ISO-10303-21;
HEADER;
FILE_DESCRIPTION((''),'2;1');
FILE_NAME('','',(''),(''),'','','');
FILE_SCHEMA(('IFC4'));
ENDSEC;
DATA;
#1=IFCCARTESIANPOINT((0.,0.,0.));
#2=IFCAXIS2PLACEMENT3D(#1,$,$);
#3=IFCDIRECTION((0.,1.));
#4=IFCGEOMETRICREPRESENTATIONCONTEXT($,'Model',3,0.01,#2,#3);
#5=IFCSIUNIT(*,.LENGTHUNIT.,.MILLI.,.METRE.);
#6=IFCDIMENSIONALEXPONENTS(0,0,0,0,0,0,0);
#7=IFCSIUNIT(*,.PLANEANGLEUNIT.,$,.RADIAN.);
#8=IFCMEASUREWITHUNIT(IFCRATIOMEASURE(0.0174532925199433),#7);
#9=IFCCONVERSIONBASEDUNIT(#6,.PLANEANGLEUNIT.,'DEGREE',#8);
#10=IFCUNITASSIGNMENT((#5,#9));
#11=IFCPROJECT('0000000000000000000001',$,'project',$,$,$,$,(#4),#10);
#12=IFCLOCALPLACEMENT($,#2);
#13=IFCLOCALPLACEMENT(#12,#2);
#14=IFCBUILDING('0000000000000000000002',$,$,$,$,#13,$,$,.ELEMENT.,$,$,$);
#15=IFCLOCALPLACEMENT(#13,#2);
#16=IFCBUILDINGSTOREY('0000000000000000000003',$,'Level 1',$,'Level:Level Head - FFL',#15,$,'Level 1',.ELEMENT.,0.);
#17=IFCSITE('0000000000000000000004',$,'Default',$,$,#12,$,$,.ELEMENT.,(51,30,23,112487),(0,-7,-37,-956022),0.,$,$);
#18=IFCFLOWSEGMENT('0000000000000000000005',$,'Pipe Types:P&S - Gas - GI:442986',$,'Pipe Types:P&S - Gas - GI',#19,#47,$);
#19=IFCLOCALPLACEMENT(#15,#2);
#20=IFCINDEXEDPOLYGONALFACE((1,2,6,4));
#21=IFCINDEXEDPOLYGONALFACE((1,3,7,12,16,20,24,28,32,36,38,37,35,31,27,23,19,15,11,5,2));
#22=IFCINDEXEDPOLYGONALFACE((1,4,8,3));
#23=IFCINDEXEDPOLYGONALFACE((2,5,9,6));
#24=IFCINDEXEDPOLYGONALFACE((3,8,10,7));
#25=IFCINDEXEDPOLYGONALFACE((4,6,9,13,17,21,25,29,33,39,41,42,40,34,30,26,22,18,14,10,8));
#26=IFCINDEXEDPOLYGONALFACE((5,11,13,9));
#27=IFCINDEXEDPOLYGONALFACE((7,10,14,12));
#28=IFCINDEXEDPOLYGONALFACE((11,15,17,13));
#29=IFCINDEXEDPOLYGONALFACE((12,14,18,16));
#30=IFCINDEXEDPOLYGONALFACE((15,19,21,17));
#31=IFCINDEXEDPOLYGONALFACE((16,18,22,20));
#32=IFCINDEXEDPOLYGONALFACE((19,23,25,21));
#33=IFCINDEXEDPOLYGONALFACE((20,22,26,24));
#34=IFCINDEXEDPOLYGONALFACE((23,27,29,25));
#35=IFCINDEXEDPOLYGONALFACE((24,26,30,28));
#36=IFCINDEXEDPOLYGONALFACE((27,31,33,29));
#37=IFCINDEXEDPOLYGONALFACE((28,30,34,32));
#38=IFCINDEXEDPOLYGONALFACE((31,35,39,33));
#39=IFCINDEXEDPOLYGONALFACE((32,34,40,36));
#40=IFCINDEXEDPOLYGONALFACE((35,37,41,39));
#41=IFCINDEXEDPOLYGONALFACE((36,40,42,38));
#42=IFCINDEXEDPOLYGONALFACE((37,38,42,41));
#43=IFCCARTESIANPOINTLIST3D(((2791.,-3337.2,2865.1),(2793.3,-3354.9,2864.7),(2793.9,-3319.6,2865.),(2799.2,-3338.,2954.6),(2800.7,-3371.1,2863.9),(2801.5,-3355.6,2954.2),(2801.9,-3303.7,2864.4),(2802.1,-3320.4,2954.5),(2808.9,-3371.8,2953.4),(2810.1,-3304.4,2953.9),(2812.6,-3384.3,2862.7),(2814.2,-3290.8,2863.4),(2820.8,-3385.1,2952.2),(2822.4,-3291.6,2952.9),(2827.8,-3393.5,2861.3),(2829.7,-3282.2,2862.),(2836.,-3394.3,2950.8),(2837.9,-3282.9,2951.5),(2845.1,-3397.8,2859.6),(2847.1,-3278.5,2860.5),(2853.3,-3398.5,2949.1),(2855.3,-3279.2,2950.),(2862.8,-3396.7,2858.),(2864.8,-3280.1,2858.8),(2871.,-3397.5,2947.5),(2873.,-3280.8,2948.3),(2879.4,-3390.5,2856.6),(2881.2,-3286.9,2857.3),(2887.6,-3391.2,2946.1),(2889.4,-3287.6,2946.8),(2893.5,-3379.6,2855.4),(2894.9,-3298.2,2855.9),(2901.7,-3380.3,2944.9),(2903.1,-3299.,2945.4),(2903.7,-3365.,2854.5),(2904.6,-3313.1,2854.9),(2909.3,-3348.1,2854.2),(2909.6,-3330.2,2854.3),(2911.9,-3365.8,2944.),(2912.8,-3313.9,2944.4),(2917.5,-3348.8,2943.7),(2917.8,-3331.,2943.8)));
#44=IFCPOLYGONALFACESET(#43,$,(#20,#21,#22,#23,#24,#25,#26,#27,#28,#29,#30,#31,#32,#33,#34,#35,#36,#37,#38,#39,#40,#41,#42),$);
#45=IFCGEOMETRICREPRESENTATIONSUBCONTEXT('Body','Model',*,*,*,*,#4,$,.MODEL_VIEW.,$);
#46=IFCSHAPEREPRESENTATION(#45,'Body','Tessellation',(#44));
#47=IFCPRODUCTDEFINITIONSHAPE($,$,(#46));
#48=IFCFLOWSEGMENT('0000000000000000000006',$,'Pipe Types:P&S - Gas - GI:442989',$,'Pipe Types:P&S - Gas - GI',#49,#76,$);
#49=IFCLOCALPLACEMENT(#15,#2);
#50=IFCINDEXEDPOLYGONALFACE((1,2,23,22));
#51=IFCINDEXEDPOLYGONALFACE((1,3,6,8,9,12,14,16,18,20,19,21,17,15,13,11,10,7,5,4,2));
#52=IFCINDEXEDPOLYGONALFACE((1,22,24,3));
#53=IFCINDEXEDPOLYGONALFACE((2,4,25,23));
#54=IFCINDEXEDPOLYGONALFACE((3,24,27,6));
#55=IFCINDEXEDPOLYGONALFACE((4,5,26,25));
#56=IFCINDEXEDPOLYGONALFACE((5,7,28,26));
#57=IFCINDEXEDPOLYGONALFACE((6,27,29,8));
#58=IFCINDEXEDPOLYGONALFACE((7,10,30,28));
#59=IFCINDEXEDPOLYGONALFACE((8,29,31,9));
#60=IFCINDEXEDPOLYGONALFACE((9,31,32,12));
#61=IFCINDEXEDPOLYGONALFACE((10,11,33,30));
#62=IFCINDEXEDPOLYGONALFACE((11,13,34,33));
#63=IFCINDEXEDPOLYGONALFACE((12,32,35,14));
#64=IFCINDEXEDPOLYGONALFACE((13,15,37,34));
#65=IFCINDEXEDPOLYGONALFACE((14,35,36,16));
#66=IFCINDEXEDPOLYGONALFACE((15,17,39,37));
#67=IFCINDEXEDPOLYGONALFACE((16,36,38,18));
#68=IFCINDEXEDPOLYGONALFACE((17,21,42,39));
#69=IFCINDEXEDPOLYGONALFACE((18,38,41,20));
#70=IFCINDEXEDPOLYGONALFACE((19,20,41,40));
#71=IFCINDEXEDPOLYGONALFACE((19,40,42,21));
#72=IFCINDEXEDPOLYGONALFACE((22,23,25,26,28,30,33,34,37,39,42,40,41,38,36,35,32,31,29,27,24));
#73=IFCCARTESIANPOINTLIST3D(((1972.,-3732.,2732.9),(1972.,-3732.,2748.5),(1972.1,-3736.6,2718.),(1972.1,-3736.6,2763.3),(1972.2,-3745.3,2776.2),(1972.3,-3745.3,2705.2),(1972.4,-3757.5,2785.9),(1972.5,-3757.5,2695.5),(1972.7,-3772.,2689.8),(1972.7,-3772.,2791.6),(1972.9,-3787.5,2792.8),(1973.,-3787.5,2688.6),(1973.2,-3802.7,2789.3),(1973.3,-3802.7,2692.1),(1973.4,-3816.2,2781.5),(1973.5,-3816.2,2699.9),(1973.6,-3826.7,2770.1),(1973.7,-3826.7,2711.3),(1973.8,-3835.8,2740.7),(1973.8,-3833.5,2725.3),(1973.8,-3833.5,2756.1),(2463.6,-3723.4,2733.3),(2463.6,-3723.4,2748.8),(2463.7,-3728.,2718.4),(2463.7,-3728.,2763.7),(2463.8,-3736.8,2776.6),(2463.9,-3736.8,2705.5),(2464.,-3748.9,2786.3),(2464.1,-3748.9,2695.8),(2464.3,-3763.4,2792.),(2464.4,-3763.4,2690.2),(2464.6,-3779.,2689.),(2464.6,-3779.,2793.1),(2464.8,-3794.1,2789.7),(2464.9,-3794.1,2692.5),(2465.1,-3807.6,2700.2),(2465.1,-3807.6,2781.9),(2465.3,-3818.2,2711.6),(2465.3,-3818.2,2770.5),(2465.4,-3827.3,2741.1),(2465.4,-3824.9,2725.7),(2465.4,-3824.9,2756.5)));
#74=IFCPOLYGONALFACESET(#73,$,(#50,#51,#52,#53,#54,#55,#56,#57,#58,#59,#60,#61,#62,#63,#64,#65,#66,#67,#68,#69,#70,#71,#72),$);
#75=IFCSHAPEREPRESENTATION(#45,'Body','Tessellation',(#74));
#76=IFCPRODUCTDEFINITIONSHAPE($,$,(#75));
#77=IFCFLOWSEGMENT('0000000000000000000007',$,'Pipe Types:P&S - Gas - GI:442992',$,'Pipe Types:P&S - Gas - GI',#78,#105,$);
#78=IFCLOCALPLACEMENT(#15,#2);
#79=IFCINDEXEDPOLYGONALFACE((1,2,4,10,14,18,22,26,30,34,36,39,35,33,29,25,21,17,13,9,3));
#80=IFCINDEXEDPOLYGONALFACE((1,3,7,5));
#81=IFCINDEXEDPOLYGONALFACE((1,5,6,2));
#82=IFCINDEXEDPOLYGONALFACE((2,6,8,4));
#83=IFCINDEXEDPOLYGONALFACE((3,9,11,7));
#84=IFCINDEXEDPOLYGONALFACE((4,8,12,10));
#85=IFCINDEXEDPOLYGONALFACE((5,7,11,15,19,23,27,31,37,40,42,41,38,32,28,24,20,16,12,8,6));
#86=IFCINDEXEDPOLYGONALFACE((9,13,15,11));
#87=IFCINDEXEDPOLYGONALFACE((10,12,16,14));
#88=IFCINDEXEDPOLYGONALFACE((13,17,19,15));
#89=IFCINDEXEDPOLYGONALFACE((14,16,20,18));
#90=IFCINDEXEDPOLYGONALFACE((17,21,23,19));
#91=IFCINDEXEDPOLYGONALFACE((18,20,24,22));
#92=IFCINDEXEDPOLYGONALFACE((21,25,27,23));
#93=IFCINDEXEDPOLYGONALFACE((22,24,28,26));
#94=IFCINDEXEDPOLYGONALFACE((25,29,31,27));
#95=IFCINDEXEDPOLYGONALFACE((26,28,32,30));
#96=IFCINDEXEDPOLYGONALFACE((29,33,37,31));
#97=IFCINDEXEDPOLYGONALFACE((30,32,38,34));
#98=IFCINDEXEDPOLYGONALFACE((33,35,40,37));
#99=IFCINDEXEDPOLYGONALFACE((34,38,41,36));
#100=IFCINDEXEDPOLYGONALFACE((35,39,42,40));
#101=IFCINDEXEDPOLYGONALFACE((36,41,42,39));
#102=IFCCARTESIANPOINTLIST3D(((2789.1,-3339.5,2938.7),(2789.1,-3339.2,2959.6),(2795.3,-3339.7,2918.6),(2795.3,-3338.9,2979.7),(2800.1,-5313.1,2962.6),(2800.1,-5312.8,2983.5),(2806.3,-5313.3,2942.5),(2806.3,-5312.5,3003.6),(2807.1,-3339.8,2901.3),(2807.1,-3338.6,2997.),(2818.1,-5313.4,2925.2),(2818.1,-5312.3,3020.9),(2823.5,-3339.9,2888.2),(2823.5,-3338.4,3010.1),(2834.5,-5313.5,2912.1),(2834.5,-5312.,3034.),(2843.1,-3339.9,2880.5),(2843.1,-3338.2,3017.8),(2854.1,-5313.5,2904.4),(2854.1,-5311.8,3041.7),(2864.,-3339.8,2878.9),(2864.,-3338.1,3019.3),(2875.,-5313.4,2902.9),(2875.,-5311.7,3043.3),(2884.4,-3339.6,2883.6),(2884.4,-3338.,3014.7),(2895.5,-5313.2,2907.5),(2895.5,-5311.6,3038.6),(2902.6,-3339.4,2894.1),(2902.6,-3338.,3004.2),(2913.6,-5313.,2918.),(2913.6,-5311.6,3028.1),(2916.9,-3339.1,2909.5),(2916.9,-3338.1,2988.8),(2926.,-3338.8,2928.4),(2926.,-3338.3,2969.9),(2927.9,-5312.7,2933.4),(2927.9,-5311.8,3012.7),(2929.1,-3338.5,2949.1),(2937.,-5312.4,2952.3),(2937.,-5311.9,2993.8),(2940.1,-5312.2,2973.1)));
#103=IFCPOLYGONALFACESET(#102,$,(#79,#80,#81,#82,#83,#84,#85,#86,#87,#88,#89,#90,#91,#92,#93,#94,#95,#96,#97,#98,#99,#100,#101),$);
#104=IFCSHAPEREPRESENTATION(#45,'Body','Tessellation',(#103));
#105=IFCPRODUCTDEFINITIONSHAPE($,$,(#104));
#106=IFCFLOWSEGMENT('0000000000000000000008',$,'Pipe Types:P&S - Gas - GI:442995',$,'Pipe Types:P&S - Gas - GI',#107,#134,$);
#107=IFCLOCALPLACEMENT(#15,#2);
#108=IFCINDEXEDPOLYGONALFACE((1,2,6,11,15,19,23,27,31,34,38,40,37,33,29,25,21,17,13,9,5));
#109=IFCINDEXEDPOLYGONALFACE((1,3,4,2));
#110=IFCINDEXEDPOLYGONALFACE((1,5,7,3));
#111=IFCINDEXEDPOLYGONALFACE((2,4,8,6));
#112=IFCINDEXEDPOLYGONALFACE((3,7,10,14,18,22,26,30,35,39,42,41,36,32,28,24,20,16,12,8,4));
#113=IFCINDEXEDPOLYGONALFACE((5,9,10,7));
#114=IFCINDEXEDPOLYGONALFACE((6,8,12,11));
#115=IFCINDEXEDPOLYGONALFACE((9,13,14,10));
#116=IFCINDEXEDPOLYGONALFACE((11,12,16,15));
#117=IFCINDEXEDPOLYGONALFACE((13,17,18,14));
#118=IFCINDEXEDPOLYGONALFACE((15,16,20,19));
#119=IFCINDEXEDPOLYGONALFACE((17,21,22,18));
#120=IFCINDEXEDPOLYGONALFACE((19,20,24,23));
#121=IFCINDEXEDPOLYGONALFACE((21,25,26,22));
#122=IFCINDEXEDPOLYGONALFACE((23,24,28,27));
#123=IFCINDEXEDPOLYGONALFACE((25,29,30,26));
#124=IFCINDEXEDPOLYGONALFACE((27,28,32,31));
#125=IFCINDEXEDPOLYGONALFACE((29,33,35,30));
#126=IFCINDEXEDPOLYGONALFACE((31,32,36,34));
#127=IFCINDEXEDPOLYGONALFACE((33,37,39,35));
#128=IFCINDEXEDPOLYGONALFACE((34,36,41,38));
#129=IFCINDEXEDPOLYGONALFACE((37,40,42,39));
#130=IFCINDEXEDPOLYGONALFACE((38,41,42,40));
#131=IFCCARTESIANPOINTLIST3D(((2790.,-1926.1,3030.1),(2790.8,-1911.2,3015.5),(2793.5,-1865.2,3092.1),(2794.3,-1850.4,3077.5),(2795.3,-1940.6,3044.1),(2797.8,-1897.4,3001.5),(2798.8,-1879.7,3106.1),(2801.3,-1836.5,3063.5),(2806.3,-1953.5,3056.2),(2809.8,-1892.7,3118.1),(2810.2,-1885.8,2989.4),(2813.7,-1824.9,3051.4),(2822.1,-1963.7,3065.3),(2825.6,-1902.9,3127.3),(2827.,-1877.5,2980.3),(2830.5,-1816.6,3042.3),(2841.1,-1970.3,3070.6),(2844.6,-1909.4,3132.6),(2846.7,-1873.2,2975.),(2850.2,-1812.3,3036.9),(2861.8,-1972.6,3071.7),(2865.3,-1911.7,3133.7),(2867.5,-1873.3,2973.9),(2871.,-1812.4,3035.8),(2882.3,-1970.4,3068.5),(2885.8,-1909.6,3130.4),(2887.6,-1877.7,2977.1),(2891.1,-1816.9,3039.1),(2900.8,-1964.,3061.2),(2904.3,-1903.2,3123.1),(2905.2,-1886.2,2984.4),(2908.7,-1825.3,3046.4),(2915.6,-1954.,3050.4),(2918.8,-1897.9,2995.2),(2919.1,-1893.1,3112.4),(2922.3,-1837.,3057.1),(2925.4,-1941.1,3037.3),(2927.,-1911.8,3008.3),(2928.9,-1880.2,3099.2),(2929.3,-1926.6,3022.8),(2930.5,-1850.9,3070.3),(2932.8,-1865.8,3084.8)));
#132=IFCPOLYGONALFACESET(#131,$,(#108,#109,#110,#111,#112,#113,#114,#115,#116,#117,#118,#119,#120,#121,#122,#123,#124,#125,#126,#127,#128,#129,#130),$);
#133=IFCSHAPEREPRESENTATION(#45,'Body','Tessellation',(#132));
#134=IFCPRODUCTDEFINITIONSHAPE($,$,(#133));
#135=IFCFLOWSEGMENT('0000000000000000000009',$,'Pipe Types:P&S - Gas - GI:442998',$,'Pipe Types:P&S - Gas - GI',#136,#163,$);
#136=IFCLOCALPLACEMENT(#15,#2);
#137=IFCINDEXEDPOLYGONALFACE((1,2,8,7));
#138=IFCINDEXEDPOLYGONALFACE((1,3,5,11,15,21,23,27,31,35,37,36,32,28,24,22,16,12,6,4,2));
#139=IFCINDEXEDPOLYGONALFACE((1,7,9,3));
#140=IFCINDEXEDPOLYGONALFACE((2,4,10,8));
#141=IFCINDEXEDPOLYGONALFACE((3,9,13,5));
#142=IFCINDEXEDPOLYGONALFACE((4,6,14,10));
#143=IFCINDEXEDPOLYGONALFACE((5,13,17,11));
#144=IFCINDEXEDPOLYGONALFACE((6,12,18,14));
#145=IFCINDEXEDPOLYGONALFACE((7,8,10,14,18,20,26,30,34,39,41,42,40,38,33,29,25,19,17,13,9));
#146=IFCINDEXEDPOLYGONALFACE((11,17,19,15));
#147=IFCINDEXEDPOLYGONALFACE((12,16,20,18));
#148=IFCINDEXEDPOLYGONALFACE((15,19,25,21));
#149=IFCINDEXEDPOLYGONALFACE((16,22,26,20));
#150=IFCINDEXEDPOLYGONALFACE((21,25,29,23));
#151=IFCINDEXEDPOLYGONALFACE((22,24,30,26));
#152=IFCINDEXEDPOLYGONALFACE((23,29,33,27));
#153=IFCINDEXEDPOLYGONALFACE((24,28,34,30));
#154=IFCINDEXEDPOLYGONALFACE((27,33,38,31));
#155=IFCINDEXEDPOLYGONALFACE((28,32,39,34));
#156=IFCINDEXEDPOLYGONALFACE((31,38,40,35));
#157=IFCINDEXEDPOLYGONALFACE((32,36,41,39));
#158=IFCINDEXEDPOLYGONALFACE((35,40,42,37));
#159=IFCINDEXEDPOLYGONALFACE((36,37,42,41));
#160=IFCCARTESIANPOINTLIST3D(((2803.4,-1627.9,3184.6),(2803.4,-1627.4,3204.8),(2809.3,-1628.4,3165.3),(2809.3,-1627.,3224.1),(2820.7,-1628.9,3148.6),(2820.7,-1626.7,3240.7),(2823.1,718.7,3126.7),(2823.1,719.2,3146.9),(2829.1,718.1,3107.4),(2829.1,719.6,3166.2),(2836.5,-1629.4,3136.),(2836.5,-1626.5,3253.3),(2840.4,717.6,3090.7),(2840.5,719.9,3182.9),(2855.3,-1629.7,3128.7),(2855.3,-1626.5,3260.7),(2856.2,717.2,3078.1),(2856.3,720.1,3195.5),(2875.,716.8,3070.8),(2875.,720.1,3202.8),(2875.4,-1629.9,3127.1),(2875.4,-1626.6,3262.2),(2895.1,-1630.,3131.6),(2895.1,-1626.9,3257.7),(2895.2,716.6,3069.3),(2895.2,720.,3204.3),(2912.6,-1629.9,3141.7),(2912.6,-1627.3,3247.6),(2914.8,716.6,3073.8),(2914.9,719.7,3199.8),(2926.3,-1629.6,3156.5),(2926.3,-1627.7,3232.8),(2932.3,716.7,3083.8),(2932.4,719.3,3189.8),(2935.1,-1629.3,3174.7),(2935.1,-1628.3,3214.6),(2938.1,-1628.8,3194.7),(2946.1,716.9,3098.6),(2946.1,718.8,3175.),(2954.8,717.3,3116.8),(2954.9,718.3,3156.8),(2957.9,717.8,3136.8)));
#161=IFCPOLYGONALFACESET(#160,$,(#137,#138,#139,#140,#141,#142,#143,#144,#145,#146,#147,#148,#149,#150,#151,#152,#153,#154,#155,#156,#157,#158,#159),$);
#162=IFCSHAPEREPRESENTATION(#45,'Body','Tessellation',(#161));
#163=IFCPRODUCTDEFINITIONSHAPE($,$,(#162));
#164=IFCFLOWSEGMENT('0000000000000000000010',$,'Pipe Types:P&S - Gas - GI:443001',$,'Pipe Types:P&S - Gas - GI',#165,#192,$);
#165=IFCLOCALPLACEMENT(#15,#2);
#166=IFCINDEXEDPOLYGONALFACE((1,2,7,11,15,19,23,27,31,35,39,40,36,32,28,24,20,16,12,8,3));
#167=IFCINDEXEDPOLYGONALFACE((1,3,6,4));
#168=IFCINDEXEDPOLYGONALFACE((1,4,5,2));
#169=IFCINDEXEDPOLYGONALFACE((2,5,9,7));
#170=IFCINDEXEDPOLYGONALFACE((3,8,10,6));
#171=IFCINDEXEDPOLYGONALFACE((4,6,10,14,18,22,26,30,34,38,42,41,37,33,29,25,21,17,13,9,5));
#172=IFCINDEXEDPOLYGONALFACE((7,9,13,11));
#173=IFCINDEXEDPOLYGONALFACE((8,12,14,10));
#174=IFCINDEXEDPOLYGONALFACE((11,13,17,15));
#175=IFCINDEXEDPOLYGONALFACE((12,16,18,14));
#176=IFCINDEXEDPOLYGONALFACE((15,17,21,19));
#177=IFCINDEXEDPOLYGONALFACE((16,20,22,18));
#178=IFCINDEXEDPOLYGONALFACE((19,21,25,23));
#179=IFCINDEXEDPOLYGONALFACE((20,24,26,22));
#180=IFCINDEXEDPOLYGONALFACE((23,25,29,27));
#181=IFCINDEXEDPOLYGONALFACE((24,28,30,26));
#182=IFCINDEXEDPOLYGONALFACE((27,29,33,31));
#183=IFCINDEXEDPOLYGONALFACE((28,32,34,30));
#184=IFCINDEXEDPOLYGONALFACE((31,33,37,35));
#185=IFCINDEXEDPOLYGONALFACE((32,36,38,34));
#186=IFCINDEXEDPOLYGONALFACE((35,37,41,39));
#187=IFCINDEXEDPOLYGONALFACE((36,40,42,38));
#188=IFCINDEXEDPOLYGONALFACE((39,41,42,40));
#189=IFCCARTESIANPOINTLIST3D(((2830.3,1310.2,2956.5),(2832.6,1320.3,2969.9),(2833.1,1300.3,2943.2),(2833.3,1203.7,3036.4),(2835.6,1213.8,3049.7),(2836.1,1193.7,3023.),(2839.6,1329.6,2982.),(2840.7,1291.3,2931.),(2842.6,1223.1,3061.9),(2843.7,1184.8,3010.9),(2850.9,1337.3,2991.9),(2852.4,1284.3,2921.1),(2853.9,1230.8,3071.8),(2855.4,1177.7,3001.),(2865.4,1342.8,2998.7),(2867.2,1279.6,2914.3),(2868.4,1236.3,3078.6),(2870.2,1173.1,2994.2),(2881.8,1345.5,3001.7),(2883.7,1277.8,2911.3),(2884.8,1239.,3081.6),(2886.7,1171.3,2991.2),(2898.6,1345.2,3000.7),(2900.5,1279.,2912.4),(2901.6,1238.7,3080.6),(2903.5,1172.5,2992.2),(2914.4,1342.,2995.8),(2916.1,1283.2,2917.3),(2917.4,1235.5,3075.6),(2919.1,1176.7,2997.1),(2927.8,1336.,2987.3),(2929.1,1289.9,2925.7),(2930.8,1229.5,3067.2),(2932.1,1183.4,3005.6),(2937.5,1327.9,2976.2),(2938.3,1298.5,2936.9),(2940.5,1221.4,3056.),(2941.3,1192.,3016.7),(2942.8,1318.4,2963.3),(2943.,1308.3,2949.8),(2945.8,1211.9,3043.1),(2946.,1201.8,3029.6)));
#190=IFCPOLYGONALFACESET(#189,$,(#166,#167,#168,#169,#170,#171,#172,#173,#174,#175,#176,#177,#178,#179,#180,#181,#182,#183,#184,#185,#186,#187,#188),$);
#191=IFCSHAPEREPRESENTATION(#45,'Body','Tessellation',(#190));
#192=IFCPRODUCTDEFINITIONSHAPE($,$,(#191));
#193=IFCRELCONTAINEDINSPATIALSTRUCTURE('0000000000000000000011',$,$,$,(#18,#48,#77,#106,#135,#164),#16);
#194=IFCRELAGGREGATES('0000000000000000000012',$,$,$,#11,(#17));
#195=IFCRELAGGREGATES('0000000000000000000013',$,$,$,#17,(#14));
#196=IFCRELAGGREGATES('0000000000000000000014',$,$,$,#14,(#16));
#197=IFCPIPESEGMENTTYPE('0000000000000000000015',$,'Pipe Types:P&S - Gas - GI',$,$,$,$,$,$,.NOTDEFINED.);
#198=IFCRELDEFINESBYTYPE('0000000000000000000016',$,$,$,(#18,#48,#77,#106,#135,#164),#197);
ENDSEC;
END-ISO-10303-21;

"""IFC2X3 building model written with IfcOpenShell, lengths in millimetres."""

from ifc_helpers import new_model, entity, si_unit, converted_unit, direction, frame, frame_2d, origin, origin_2d_with_axis, place, context, subcontext, project, spatial, circle, extrude, type_object, element, save


model = new_model("IFC2X3")

# Units and contexts
model_context = context("Model", 3, precision=0.01, world=origin(), true_north=direction((0.0, 1.0)))
body_context = subcontext(model_context, "Body", "Model", "MODEL_VIEW")
ifc_project = project(units=[si_unit("LENGTHUNIT", "METRE", prefix="MILLI"), converted_unit("PLANEANGLEUNIT", "DEGREE", entity("IfcRatioMeasure", 0.0174532925199433), si_unit("PLANEANGLEUNIT", "RADIAN"), dimensions=[0, 0, 0, 0, 0, 0, 0])], contexts=[model_context])

# Site, building, storey
site_placement = place(None, origin())
site = spatial("IfcSite", under=ifc_project, at=site_placement, Name="Default", CompositionType="ELEMENT", RefLatitude=(51, 30, 23, 112487), RefLongitude=(0, -7, -37, -956022), RefElevation=0.0)
building_placement = place(site_placement, origin())
building = spatial("IfcBuilding", under=site, at=building_placement, CompositionType="ELEMENT")
storey_placement = place(building_placement, origin())
storey = spatial("IfcBuildingStorey", under=building, at=storey_placement, Name="Level 1", ObjectType="Level:Level Head - FFL", LongName="Level 1", CompositionType="ELEMENT", Elevation=0.0)

# Flow segments
pipe_segment_type = type_object("IfcPipeSegmentType", Name="Pipe Types:P&S - Gas - GI", PredefinedType="NOTDEFINED")
flow_segment_1_placement = place(storey_placement, origin())
element("IfcFlowSegment", 1, at=flow_segment_1_placement, inside=storey, type_object=pipe_segment_type, Name="Pipe Types:P&S - Gas - GI:442986", ObjectType="Pipe Types:P&S - Gas - GI", context=body_context, shape_type="SweptSolid", body=[
    extrude(circle(Radius=59.8, at=frame_2d((0.0, 0.0), x_axis=(1.0, 0.0))), frame((2850.5, -3338.2, 2859.6), z_axis=(0.091223, -0.008361, 0.995795), x_axis=(-0.091274, -0.995826, 0.0)), (0.0, 0.0, 1.0), 89.9),
])
flow_segment_2_placement = place(storey_placement, origin())
element("IfcFlowSegment", 2, at=flow_segment_2_placement, inside=storey, type_object=pipe_segment_type, Name="Pipe Types:P&S - Gas - GI:442989", ObjectType="Pipe Types:P&S - Gas - GI", context=body_context, shape_type="SweptSolid", body=[
    extrude(circle(Radius=52.2, at=frame_2d((0.0, 0.0), x_axis=(1.0, 0.0))), frame((1972.9, -3783.6, 2740.7), z_axis=(0.999848, 0.017396, 0.000768), x_axis=(0.017396, -0.999849, 0.0)), (0.0, 0.0, 1.0), 491.7),
])
flow_segment_3_placement = place(storey_placement, origin())
element("IfcFlowSegment", 3, at=flow_segment_3_placement, inside=storey, type_object=pipe_segment_type, Name="Pipe Types:P&S - Gas - GI:442992", ObjectType="Pipe Types:P&S - Gas - GI", context=body_context, shape_type="SweptSolid", body=[
    extrude(circle(Radius=70.4, at=frame_2d((0.0, 0.0), x_axis=(1.0, 0.0))), frame((2858.7, -3338.9, 2949.1), z_axis=(0.005584, -0.999911, 0.012117), x_axis=(0.999984, 0.005584, 0.0)), (0.0, 0.0, 1.0), 1973.8),
])
flow_segment_4_placement = place(storey_placement, origin())
element("IfcFlowSegment", 4, at=flow_segment_4_placement, inside=storey, type_object=pipe_segment_type, Name="Pipe Types:P&S - Gas - GI:442995", ObjectType="Pipe Types:P&S - Gas - GI", context=body_context, shape_type="SweptSolid", body=[
    extrude(circle(Radius=70.0, at=origin_2d_with_axis()), frame((2859.5, -1922.6, 3022.8), z_axis=(0.040143, 0.700137, 0.712879), x_axis=(0.99836, -0.057242, 0.0)), (0.0, 0.0, 1.0), 86.9),
])
flow_segment_5_placement = place(storey_placement, origin())
element("IfcFlowSegment", 5, at=flow_segment_5_placement, inside=storey, type_object=pipe_segment_type, Name="Pipe Types:P&S - Gas - GI:442998", ObjectType="Pipe Types:P&S - Gas - GI", context=body_context, shape_type="SweptSolid", body=[
    extrude(circle(Radius=67.7, at=origin_2d_with_axis()), frame((2870.3, -1628.2, 3194.7), z_axis=(0.008422, 0.99966, -0.024657), x_axis=(0.999965, -0.008424, 0.0)), (0.0, 0.0, 1.0), 2347.4),
])
flow_segment_6_placement = place(storey_placement, origin())
element("IfcFlowSegment", 6, at=flow_segment_6_placement, inside=storey, type_object=pipe_segment_type, Name="Pipe Types:P&S - Gas - GI:443001", ObjectType="Pipe Types:P&S - Gas - GI", context=body_context, shape_type="SweptSolid", body=[
    extrude(circle(Radius=56.6, at=frame_2d((0.0, 0.0), x_axis=(1.0, 0.0))), frame((2889.9, 1205.3, 3036.4), z_axis=(-0.022536, 0.799878, -0.59974), x_axis=(-0.999603, -0.028163, 0.0)), (0.0, 0.0, 1.0), 133.2),
])

save(model, "model.ifc")
